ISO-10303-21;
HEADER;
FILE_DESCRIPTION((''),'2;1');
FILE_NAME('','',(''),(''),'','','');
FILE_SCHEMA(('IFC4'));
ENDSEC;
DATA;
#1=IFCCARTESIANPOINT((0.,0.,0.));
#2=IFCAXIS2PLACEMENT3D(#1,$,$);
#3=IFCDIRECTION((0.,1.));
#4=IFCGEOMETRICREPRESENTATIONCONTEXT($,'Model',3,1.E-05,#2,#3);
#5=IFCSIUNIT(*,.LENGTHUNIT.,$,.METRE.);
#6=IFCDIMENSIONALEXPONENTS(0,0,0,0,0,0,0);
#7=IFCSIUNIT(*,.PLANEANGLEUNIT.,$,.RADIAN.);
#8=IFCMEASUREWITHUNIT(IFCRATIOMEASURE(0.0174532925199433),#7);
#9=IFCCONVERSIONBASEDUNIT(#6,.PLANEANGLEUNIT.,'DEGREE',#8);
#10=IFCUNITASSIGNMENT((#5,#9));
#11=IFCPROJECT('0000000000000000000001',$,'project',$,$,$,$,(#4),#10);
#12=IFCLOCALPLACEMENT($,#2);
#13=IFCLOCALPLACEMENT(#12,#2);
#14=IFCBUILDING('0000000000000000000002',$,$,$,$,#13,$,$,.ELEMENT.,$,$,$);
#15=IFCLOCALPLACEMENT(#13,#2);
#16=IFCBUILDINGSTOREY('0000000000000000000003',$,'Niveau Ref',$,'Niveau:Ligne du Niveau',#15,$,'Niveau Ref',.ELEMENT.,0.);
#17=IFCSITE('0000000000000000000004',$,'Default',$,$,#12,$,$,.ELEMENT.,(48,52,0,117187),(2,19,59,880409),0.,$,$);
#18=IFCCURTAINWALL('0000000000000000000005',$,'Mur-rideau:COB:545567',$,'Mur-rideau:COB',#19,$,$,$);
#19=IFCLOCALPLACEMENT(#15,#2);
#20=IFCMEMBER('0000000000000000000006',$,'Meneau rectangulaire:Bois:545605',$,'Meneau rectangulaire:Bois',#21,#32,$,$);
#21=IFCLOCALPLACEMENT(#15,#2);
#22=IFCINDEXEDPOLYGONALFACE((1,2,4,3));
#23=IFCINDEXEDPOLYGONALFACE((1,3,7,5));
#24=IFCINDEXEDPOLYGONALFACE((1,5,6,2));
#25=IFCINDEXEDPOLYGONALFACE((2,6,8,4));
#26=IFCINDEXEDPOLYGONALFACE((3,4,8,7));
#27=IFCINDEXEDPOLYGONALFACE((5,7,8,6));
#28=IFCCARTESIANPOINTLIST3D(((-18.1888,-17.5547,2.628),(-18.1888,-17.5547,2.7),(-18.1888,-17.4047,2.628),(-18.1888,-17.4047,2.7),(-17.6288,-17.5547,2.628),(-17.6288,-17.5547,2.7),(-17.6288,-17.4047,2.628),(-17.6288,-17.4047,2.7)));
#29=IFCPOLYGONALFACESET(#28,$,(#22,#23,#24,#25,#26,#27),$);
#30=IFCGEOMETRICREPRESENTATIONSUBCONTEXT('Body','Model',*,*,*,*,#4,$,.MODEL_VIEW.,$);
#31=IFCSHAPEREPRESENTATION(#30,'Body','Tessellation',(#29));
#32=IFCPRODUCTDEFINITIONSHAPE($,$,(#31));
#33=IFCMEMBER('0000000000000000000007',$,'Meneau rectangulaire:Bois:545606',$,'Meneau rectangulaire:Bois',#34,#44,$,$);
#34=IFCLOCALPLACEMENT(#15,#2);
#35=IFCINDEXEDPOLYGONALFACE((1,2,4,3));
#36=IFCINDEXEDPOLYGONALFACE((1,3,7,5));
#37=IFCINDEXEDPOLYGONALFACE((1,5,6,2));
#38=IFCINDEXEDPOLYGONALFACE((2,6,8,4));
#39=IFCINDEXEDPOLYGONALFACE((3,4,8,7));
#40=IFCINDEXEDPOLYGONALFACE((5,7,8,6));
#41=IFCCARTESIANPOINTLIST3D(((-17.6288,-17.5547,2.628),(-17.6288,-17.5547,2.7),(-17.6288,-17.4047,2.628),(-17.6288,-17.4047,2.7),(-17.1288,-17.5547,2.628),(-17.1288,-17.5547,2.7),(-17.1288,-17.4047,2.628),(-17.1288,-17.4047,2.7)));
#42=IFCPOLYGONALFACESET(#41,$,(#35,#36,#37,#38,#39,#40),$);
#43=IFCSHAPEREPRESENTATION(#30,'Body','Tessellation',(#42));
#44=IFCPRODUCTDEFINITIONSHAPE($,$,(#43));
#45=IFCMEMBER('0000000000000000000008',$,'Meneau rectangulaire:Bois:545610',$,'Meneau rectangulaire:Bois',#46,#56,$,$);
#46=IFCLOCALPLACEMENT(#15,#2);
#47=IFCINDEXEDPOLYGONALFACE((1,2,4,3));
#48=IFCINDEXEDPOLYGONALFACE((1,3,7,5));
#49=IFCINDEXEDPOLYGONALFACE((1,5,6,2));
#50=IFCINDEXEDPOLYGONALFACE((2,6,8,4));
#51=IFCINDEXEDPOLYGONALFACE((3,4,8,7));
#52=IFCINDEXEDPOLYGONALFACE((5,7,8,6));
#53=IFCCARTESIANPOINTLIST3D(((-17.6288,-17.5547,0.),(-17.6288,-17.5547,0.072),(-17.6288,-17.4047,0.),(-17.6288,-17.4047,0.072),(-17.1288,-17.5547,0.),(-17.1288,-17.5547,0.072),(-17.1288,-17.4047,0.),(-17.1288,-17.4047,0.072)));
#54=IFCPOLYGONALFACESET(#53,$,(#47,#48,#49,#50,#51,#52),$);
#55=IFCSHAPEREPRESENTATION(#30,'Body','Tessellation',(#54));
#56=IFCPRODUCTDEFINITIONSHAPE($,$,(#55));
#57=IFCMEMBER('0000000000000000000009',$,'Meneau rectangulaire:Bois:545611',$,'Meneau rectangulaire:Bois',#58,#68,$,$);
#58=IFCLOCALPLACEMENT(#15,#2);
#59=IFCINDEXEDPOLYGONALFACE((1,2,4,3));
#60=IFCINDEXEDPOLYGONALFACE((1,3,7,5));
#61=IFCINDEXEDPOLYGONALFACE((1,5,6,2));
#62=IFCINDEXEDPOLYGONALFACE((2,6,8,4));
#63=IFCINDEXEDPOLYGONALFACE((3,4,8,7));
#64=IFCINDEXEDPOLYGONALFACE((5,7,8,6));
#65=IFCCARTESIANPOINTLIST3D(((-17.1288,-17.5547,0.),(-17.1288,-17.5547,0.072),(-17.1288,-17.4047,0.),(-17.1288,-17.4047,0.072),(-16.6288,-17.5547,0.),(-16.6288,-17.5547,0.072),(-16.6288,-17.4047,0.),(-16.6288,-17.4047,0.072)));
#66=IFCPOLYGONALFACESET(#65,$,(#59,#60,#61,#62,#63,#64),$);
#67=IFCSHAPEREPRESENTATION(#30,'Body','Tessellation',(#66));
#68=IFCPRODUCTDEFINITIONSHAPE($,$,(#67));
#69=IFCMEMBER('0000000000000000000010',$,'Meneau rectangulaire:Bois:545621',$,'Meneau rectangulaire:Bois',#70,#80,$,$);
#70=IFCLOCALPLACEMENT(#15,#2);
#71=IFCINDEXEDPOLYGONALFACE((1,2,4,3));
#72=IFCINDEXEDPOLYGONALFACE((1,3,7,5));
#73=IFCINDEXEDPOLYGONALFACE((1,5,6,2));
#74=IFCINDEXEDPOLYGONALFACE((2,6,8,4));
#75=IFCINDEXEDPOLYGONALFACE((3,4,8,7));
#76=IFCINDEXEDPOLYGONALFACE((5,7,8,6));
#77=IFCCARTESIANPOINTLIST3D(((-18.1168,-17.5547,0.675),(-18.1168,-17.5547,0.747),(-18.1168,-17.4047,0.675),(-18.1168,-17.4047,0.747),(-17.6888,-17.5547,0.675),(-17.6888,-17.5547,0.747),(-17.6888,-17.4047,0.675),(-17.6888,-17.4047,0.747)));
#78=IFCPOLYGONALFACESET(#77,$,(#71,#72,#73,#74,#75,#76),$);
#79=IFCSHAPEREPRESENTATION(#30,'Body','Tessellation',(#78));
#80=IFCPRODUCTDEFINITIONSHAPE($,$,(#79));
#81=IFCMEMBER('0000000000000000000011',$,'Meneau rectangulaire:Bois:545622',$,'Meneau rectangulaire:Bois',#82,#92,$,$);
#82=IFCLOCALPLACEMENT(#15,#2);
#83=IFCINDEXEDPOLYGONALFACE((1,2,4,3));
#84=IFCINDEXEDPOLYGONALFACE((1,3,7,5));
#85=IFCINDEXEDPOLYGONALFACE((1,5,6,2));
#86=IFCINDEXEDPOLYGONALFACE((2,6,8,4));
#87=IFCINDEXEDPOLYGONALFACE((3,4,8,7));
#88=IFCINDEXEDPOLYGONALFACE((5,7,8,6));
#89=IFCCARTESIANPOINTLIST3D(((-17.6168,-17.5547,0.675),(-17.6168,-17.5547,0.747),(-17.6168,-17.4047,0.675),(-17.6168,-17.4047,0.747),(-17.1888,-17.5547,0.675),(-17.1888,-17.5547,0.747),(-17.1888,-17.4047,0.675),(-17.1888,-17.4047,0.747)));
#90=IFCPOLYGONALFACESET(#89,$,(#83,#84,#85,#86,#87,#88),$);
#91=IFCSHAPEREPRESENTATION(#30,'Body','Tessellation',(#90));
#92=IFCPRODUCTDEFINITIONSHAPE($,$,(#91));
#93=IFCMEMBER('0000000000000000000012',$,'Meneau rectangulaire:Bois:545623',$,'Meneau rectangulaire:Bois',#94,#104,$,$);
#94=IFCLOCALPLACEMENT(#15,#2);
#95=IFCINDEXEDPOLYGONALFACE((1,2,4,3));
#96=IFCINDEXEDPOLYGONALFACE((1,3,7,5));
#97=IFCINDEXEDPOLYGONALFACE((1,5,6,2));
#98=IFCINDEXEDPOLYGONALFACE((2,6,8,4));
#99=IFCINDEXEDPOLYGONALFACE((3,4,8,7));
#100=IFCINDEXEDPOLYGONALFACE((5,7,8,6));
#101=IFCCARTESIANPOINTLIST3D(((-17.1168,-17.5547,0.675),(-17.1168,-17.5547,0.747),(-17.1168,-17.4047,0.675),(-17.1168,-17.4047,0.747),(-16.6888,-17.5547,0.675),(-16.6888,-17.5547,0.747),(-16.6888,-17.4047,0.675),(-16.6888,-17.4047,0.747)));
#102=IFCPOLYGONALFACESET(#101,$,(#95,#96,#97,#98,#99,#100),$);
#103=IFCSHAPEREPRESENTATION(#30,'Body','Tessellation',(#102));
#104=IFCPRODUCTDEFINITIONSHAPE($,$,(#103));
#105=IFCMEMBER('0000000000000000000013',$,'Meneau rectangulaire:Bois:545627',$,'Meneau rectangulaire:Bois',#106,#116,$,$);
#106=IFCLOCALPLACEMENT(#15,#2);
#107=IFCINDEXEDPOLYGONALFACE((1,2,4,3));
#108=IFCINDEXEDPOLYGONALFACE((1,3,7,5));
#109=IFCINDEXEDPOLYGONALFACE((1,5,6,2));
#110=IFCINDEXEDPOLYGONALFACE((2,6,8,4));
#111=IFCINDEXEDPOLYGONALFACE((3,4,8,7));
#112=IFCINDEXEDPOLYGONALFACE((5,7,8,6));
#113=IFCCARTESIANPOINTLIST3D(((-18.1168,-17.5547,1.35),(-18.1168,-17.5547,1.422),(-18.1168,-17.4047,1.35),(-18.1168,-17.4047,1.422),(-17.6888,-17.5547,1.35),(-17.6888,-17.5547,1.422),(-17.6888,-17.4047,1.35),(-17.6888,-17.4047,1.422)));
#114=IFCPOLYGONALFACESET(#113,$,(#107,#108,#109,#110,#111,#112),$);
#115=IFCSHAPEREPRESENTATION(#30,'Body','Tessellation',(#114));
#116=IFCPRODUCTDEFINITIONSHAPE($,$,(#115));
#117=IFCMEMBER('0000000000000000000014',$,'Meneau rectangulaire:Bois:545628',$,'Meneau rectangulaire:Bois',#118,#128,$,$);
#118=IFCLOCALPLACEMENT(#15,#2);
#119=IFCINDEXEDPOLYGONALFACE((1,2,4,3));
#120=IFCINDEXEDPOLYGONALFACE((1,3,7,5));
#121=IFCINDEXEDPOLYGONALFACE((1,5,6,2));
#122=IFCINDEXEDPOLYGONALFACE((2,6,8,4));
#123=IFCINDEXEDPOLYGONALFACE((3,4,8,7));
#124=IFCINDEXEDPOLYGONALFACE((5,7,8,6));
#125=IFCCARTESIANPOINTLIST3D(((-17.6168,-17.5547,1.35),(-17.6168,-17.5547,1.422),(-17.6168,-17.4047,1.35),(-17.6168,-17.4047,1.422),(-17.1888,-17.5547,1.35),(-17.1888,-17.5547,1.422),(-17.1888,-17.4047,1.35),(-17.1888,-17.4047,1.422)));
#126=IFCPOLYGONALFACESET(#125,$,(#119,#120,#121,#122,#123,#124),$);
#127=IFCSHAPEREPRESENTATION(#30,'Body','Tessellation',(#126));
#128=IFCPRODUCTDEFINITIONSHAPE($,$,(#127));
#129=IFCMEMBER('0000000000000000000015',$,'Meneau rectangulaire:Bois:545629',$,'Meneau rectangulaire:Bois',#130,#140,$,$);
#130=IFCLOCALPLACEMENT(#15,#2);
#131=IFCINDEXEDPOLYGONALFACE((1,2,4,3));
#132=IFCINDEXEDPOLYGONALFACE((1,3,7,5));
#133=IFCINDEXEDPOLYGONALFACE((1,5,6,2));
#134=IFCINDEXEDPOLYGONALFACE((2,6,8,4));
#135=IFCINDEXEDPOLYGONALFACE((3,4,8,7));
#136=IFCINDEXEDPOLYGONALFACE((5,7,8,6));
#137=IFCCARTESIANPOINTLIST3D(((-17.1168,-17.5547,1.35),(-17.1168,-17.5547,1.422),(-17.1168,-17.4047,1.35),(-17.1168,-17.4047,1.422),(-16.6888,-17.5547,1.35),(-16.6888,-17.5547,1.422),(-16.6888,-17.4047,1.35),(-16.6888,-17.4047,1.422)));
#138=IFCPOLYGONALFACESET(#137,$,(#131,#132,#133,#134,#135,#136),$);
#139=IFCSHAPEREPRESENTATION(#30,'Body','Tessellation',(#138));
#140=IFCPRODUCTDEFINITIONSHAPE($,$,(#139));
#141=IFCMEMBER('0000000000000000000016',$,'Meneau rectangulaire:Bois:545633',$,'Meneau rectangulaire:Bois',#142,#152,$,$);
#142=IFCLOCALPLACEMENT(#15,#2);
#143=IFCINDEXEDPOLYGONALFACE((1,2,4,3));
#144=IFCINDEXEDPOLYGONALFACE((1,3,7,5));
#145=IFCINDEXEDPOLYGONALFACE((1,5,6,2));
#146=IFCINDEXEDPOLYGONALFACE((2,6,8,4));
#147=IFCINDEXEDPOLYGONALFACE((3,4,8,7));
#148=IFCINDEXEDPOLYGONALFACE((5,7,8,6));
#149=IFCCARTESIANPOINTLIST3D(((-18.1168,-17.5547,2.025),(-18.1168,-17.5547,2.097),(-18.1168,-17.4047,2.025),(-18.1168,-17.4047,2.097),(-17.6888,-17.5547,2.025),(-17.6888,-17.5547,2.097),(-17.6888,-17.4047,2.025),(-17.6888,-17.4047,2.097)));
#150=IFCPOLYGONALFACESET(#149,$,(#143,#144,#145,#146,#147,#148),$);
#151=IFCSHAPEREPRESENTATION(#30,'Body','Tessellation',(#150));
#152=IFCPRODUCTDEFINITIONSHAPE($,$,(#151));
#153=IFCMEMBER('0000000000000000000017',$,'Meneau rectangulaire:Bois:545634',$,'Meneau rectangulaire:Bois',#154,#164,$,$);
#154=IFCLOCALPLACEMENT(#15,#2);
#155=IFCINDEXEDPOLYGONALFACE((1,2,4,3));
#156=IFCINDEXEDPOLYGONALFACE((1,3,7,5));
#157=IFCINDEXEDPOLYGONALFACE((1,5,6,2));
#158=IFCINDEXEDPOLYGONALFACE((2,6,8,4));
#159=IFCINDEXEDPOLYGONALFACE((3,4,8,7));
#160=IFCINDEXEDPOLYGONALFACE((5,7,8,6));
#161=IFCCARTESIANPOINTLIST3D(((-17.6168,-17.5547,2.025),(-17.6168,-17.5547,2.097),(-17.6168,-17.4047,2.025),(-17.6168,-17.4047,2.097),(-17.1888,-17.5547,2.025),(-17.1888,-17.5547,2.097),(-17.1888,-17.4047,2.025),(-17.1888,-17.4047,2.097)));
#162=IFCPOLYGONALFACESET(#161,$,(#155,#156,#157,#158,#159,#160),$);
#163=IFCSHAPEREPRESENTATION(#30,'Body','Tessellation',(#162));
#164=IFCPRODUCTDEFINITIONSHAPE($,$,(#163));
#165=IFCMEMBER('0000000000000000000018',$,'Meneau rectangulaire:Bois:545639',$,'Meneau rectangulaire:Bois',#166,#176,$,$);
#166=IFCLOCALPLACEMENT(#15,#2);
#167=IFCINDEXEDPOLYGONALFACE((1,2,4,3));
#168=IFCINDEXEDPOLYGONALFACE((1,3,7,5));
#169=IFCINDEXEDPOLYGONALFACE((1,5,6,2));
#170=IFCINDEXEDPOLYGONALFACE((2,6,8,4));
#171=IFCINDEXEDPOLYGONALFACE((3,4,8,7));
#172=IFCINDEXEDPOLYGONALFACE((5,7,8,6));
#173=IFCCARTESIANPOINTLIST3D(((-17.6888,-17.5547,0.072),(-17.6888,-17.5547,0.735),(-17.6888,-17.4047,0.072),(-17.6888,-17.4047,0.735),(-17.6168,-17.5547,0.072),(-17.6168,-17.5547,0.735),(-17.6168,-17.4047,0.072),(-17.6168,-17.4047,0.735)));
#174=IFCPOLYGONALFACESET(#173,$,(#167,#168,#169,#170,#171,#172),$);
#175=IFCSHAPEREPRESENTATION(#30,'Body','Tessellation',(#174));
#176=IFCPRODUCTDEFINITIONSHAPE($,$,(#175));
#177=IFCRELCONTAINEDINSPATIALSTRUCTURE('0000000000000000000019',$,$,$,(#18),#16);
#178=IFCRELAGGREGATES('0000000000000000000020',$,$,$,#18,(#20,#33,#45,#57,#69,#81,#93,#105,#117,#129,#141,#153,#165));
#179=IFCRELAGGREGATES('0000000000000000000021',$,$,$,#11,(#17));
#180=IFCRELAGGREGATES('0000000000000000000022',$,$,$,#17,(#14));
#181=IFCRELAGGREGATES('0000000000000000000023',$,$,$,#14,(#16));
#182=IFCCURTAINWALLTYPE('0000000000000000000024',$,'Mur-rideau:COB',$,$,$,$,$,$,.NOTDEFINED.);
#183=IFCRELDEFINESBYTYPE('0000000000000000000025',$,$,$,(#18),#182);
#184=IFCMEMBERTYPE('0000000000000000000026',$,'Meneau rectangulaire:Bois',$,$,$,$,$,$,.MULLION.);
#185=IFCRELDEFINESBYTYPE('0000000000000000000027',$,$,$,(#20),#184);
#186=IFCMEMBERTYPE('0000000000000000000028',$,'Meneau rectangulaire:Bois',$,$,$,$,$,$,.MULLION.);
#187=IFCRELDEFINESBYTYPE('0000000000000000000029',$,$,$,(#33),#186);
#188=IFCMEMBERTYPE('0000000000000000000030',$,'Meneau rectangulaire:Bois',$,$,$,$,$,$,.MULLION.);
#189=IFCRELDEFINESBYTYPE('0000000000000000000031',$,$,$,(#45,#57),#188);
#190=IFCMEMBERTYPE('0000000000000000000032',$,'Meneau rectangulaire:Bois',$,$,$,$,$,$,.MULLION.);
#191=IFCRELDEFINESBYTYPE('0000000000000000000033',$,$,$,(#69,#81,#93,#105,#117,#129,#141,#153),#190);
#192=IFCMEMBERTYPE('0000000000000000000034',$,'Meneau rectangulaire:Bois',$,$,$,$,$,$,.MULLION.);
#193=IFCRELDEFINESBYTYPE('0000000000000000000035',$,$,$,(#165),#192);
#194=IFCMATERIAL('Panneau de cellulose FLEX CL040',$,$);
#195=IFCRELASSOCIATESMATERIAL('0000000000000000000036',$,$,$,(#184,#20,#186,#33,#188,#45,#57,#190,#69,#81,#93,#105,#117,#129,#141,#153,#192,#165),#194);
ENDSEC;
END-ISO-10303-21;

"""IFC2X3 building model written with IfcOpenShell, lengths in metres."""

from ifc_helpers import new_model, entity, si_unit, converted_unit, direction, frame, origin, origin_2d_with_axis, place, context, subcontext, project, spatial, rectangle, extrude, source, transform, mapped, material, type_object, type_shapes, element, aggregate, save


model = new_model("IFC2X3")

# Units and contexts
model_context = context("Model", 3, precision=1e-05, world=origin(), true_north=direction((0.0, 1.0)))
body_context = subcontext(model_context, "Body", "Model", "MODEL_VIEW")
ifc_project = project(units=[si_unit("LENGTHUNIT", "METRE"), converted_unit("PLANEANGLEUNIT", "DEGREE", entity("IfcRatioMeasure", 0.0174532925199433), si_unit("PLANEANGLEUNIT", "RADIAN"), dimensions=[0, 0, 0, 0, 0, 0, 0])], contexts=[model_context])

# Site, building, storey
site_placement = place(None, origin())
site = spatial("IfcSite", under=ifc_project, at=site_placement, Name="Default", CompositionType="ELEMENT", RefLatitude=(48, 52, 0, 117187), RefLongitude=(2, 19, 59, 880409), RefElevation=0.0)
building_placement = place(site_placement, origin())
building = spatial("IfcBuilding", under=site, at=building_placement, CompositionType="ELEMENT")
storey_placement = place(building_placement, origin())
storey = spatial("IfcBuildingStorey", under=building, at=storey_placement, Name="Niveau Ref", ObjectType="Niveau:Ligne du Niveau", LongName="Niveau Ref", CompositionType="ELEMENT", Elevation=0.0)

# Curtain wall, members
curtain_wall_type_1 = type_object("IfcCurtainWallType", Name="Mur-rideau:COB", PredefinedType="NOTDEFINED")
curtain_wall_1_placement = place(storey_placement, origin())
curtain_wall_1 = element("IfcCurtainWall", 1, at=curtain_wall_1_placement, inside=storey, type_object=curtain_wall_type_1, Name="Mur-rideau:COB:545567", ObjectType="Mur-rideau:COB")
ifc_material_1 = material(Name="Panneau de cellulose FLEX CL040")
member_type_1 = type_object("IfcMemberType", Name="Meneau rectangulaire:Bois", PredefinedType="MULLION", material=ifc_material_1)
shared_shape_1 = source(origin(), body_context, "Body", "SweptSolid", [
    extrude(rectangle(XDim=0.15, YDim=0.072, at=origin_2d_with_axis()), frame((-0.036, 0.0, -0.56), z_axis=(0.0, 0.0, 1.0), x_axis=(0.0, -1.0, 0.0)), (0.0, 0.0, 1.0), 0.56),
])
type_shapes(member_type_1, [shared_shape_1])
member_1_placement = place(storey_placement, frame((-17.6288, -17.4797, 2.7), z_axis=(1.0, 0.0, 0.0), x_axis=(0.0, 0.0, 1.0)))
member_1 = element("IfcMember", 2, at=member_1_placement, type_object=member_type_1, material=ifc_material_1, Name="Meneau rectangulaire:Bois:545605", ObjectType="Meneau rectangulaire:Bois", context=body_context, shape_type="MappedRepresentation", body=[
    mapped(shared_shape_1, transform((0.0, 0.0, 0.0), scale=1.0)),
])
member_type_2 = type_object("IfcMemberType", Name="Meneau rectangulaire:Bois", PredefinedType="MULLION", material=ifc_material_1)
shared_shape_2 = source(origin(), body_context, "Body", "SweptSolid", [
    extrude(rectangle(XDim=0.15, YDim=0.072, at=origin_2d_with_axis()), frame((-0.036, 0.0, -0.5), z_axis=(0.0, 0.0, 1.0), x_axis=(0.0, -1.0, 0.0)), (0.0, 0.0, 1.0), 0.5),
])
type_shapes(member_type_2, [shared_shape_2])
member_2_placement = place(storey_placement, frame((-17.1288, -17.4797, 2.7), z_axis=(1.0, 0.0, 0.0), x_axis=(0.0, 0.0, 1.0)))
member_2 = element("IfcMember", 3, at=member_2_placement, type_object=member_type_2, material=ifc_material_1, Name="Meneau rectangulaire:Bois:545606", ObjectType="Meneau rectangulaire:Bois", context=body_context, shape_type="MappedRepresentation", body=[
    mapped(shared_shape_2, transform((0.0, 0.0, 0.0), scale=1.0)),
])
member_type_3 = type_object("IfcMemberType", Name="Meneau rectangulaire:Bois", PredefinedType="MULLION", material=ifc_material_1)
shared_shape_3 = source(origin(), body_context, "Body", "SweptSolid", [
    extrude(rectangle(XDim=0.15, YDim=0.072, at=origin_2d_with_axis()), frame((-0.036, 0.0, -0.5), z_axis=(0.0, 0.0, 1.0), x_axis=(0.0, -1.0, 0.0)), (0.0, 0.0, 1.0), 0.5),
])
type_shapes(member_type_3, [shared_shape_3])
member_3_placement = place(storey_placement, frame((-17.6288, -17.4797, 0.0), z_axis=(-1.0, 0.0, 0.0), x_axis=(0.0, 0.0, -1.0)))
member_3 = element("IfcMember", 4, at=member_3_placement, type_object=member_type_3, material=ifc_material_1, Name="Meneau rectangulaire:Bois:545610", ObjectType="Meneau rectangulaire:Bois", context=body_context, shape_type="MappedRepresentation", body=[
    mapped(shared_shape_3, transform((0.0, 0.0, 0.0), scale=1.0)),
])
member_4_placement = place(storey_placement, frame((-17.1288, -17.4797, 0.0), z_axis=(-1.0, 0.0, 0.0), x_axis=(0.0, 0.0, -1.0)))
member_4 = element("IfcMember", 5, at=member_4_placement, type_object=member_type_3, material=ifc_material_1, Name="Meneau rectangulaire:Bois:545611", ObjectType="Meneau rectangulaire:Bois", context=body_context, shape_type="MappedRepresentation", body=[
    mapped(shared_shape_3, transform((0.0, 0.0, 0.0), scale=1.0)),
])
member_type_4 = type_object("IfcMemberType", Name="Meneau rectangulaire:Bois", PredefinedType="MULLION", material=ifc_material_1)
shared_shape_4 = source(origin(), body_context, "Body", "SweptSolid", [
    extrude(rectangle(XDim=0.15, YDim=0.072, at=origin_2d_with_axis()), frame((-0.024, 0.0, -0.428), z_axis=(0.0, 0.0, 1.0), x_axis=(0.0, -1.0, 0.0)), (0.0, 0.0, 1.0), 0.428),
])
type_shapes(member_type_4, [shared_shape_4])
member_5_placement = place(storey_placement, frame((-17.6888, -17.4797, 0.735), z_axis=(1.0, 0.0, 0.0), x_axis=(0.0, 0.0, 1.0)))
member_5 = element("IfcMember", 6, at=member_5_placement, type_object=member_type_4, material=ifc_material_1, Name="Meneau rectangulaire:Bois:545621", ObjectType="Meneau rectangulaire:Bois", context=body_context, shape_type="MappedRepresentation", body=[
    mapped(shared_shape_4, transform((0.0, 0.0, 0.0), scale=1.0)),
])
member_6_placement = place(storey_placement, frame((-17.1888, -17.4797, 0.735), z_axis=(1.0, 0.0, 0.0), x_axis=(0.0, 0.0, 1.0)))
member_6 = element("IfcMember", 7, at=member_6_placement, type_object=member_type_4, material=ifc_material_1, Name="Meneau rectangulaire:Bois:545622", ObjectType="Meneau rectangulaire:Bois", context=body_context, shape_type="MappedRepresentation", body=[
    mapped(shared_shape_4, transform((0.0, 0.0, 0.0), scale=1.0)),
])
member_7_placement = place(storey_placement, frame((-16.6888, -17.4797, 0.735), z_axis=(1.0, 0.0, 0.0), x_axis=(0.0, 0.0, 1.0)))
member_7 = element("IfcMember", 8, at=member_7_placement, type_object=member_type_4, material=ifc_material_1, Name="Meneau rectangulaire:Bois:545623", ObjectType="Meneau rectangulaire:Bois", context=body_context, shape_type="MappedRepresentation", body=[
    mapped(shared_shape_4, transform((0.0, 0.0, 0.0), scale=1.0)),
])
member_8_placement = place(storey_placement, frame((-17.6888, -17.4797, 1.41), z_axis=(1.0, 0.0, 0.0), x_axis=(0.0, 0.0, 1.0)))
member_8 = element("IfcMember", 9, at=member_8_placement, type_object=member_type_4, material=ifc_material_1, Name="Meneau rectangulaire:Bois:545627", ObjectType="Meneau rectangulaire:Bois", context=body_context, shape_type="MappedRepresentation", body=[
    mapped(shared_shape_4, transform((0.0, 0.0, 0.0), scale=1.0)),
])
member_9_placement = place(storey_placement, frame((-17.1888, -17.4797, 1.41), z_axis=(1.0, 0.0, 0.0), x_axis=(0.0, 0.0, 1.0)))
member_9 = element("IfcMember", 10, at=member_9_placement, type_object=member_type_4, material=ifc_material_1, Name="Meneau rectangulaire:Bois:545628", ObjectType="Meneau rectangulaire:Bois", context=body_context, shape_type="MappedRepresentation", body=[
    mapped(shared_shape_4, transform((0.0, 0.0, 0.0), scale=1.0)),
])
member_10_placement = place(storey_placement, frame((-16.6888, -17.4797, 1.41), z_axis=(1.0, 0.0, 0.0), x_axis=(0.0, 0.0, 1.0)))
member_10 = element("IfcMember", 11, at=member_10_placement, type_object=member_type_4, material=ifc_material_1, Name="Meneau rectangulaire:Bois:545629", ObjectType="Meneau rectangulaire:Bois", context=body_context, shape_type="MappedRepresentation", body=[
    mapped(shared_shape_4, transform((0.0, 0.0, 0.0), scale=1.0)),
])
member_11_placement = place(storey_placement, frame((-17.6888, -17.4797, 2.085), z_axis=(1.0, 0.0, 0.0), x_axis=(0.0, 0.0, 1.0)))
member_11 = element("IfcMember", 12, at=member_11_placement, type_object=member_type_4, material=ifc_material_1, Name="Meneau rectangulaire:Bois:545633", ObjectType="Meneau rectangulaire:Bois", context=body_context, shape_type="MappedRepresentation", body=[
    mapped(shared_shape_4, transform((0.0, 0.0, 0.0), scale=1.0)),
])
member_12_placement = place(storey_placement, frame((-17.1888, -17.4797, 2.085), z_axis=(1.0, 0.0, 0.0), x_axis=(0.0, 0.0, 1.0)))
member_12 = element("IfcMember", 13, at=member_12_placement, type_object=member_type_4, material=ifc_material_1, Name="Meneau rectangulaire:Bois:545634", ObjectType="Meneau rectangulaire:Bois", context=body_context, shape_type="MappedRepresentation", body=[
    mapped(shared_shape_4, transform((0.0, 0.0, 0.0), scale=1.0)),
])
member_type_5 = type_object("IfcMemberType", Name="Meneau rectangulaire:Bois", PredefinedType="MULLION", material=ifc_material_1)
shared_shape_5 = source(origin(), body_context, "Body", "SweptSolid", [
    extrude(rectangle(XDim=0.15, YDim=0.072, at=origin_2d_with_axis()), frame((-0.024, 0.0, -0.663), z_axis=(0.0, 0.0, 1.0), x_axis=(0.0, -1.0, 0.0)), (0.0, 0.0, 1.0), 0.663),
])
type_shapes(member_type_5, [shared_shape_5])
member_13_placement = place(storey_placement, frame((-17.6288, -17.4797, 0.072), z_axis=(0.0, 0.0, -1.0), x_axis=(1.0, 0.0, 0.0)))
member_13 = element("IfcMember", 14, at=member_13_placement, type_object=member_type_5, material=ifc_material_1, Name="Meneau rectangulaire:Bois:545639", ObjectType="Meneau rectangulaire:Bois", context=body_context, shape_type="MappedRepresentation", body=[
    mapped(shared_shape_5, transform((0.0, 0.0, 0.0), scale=1.0)),
])
aggregate(curtain_wall_1, [member_1, member_2, member_3, member_4, member_5, member_6, member_7, member_8, member_9, member_10, member_11, member_12, member_13])

save(model, "model.ifc")
